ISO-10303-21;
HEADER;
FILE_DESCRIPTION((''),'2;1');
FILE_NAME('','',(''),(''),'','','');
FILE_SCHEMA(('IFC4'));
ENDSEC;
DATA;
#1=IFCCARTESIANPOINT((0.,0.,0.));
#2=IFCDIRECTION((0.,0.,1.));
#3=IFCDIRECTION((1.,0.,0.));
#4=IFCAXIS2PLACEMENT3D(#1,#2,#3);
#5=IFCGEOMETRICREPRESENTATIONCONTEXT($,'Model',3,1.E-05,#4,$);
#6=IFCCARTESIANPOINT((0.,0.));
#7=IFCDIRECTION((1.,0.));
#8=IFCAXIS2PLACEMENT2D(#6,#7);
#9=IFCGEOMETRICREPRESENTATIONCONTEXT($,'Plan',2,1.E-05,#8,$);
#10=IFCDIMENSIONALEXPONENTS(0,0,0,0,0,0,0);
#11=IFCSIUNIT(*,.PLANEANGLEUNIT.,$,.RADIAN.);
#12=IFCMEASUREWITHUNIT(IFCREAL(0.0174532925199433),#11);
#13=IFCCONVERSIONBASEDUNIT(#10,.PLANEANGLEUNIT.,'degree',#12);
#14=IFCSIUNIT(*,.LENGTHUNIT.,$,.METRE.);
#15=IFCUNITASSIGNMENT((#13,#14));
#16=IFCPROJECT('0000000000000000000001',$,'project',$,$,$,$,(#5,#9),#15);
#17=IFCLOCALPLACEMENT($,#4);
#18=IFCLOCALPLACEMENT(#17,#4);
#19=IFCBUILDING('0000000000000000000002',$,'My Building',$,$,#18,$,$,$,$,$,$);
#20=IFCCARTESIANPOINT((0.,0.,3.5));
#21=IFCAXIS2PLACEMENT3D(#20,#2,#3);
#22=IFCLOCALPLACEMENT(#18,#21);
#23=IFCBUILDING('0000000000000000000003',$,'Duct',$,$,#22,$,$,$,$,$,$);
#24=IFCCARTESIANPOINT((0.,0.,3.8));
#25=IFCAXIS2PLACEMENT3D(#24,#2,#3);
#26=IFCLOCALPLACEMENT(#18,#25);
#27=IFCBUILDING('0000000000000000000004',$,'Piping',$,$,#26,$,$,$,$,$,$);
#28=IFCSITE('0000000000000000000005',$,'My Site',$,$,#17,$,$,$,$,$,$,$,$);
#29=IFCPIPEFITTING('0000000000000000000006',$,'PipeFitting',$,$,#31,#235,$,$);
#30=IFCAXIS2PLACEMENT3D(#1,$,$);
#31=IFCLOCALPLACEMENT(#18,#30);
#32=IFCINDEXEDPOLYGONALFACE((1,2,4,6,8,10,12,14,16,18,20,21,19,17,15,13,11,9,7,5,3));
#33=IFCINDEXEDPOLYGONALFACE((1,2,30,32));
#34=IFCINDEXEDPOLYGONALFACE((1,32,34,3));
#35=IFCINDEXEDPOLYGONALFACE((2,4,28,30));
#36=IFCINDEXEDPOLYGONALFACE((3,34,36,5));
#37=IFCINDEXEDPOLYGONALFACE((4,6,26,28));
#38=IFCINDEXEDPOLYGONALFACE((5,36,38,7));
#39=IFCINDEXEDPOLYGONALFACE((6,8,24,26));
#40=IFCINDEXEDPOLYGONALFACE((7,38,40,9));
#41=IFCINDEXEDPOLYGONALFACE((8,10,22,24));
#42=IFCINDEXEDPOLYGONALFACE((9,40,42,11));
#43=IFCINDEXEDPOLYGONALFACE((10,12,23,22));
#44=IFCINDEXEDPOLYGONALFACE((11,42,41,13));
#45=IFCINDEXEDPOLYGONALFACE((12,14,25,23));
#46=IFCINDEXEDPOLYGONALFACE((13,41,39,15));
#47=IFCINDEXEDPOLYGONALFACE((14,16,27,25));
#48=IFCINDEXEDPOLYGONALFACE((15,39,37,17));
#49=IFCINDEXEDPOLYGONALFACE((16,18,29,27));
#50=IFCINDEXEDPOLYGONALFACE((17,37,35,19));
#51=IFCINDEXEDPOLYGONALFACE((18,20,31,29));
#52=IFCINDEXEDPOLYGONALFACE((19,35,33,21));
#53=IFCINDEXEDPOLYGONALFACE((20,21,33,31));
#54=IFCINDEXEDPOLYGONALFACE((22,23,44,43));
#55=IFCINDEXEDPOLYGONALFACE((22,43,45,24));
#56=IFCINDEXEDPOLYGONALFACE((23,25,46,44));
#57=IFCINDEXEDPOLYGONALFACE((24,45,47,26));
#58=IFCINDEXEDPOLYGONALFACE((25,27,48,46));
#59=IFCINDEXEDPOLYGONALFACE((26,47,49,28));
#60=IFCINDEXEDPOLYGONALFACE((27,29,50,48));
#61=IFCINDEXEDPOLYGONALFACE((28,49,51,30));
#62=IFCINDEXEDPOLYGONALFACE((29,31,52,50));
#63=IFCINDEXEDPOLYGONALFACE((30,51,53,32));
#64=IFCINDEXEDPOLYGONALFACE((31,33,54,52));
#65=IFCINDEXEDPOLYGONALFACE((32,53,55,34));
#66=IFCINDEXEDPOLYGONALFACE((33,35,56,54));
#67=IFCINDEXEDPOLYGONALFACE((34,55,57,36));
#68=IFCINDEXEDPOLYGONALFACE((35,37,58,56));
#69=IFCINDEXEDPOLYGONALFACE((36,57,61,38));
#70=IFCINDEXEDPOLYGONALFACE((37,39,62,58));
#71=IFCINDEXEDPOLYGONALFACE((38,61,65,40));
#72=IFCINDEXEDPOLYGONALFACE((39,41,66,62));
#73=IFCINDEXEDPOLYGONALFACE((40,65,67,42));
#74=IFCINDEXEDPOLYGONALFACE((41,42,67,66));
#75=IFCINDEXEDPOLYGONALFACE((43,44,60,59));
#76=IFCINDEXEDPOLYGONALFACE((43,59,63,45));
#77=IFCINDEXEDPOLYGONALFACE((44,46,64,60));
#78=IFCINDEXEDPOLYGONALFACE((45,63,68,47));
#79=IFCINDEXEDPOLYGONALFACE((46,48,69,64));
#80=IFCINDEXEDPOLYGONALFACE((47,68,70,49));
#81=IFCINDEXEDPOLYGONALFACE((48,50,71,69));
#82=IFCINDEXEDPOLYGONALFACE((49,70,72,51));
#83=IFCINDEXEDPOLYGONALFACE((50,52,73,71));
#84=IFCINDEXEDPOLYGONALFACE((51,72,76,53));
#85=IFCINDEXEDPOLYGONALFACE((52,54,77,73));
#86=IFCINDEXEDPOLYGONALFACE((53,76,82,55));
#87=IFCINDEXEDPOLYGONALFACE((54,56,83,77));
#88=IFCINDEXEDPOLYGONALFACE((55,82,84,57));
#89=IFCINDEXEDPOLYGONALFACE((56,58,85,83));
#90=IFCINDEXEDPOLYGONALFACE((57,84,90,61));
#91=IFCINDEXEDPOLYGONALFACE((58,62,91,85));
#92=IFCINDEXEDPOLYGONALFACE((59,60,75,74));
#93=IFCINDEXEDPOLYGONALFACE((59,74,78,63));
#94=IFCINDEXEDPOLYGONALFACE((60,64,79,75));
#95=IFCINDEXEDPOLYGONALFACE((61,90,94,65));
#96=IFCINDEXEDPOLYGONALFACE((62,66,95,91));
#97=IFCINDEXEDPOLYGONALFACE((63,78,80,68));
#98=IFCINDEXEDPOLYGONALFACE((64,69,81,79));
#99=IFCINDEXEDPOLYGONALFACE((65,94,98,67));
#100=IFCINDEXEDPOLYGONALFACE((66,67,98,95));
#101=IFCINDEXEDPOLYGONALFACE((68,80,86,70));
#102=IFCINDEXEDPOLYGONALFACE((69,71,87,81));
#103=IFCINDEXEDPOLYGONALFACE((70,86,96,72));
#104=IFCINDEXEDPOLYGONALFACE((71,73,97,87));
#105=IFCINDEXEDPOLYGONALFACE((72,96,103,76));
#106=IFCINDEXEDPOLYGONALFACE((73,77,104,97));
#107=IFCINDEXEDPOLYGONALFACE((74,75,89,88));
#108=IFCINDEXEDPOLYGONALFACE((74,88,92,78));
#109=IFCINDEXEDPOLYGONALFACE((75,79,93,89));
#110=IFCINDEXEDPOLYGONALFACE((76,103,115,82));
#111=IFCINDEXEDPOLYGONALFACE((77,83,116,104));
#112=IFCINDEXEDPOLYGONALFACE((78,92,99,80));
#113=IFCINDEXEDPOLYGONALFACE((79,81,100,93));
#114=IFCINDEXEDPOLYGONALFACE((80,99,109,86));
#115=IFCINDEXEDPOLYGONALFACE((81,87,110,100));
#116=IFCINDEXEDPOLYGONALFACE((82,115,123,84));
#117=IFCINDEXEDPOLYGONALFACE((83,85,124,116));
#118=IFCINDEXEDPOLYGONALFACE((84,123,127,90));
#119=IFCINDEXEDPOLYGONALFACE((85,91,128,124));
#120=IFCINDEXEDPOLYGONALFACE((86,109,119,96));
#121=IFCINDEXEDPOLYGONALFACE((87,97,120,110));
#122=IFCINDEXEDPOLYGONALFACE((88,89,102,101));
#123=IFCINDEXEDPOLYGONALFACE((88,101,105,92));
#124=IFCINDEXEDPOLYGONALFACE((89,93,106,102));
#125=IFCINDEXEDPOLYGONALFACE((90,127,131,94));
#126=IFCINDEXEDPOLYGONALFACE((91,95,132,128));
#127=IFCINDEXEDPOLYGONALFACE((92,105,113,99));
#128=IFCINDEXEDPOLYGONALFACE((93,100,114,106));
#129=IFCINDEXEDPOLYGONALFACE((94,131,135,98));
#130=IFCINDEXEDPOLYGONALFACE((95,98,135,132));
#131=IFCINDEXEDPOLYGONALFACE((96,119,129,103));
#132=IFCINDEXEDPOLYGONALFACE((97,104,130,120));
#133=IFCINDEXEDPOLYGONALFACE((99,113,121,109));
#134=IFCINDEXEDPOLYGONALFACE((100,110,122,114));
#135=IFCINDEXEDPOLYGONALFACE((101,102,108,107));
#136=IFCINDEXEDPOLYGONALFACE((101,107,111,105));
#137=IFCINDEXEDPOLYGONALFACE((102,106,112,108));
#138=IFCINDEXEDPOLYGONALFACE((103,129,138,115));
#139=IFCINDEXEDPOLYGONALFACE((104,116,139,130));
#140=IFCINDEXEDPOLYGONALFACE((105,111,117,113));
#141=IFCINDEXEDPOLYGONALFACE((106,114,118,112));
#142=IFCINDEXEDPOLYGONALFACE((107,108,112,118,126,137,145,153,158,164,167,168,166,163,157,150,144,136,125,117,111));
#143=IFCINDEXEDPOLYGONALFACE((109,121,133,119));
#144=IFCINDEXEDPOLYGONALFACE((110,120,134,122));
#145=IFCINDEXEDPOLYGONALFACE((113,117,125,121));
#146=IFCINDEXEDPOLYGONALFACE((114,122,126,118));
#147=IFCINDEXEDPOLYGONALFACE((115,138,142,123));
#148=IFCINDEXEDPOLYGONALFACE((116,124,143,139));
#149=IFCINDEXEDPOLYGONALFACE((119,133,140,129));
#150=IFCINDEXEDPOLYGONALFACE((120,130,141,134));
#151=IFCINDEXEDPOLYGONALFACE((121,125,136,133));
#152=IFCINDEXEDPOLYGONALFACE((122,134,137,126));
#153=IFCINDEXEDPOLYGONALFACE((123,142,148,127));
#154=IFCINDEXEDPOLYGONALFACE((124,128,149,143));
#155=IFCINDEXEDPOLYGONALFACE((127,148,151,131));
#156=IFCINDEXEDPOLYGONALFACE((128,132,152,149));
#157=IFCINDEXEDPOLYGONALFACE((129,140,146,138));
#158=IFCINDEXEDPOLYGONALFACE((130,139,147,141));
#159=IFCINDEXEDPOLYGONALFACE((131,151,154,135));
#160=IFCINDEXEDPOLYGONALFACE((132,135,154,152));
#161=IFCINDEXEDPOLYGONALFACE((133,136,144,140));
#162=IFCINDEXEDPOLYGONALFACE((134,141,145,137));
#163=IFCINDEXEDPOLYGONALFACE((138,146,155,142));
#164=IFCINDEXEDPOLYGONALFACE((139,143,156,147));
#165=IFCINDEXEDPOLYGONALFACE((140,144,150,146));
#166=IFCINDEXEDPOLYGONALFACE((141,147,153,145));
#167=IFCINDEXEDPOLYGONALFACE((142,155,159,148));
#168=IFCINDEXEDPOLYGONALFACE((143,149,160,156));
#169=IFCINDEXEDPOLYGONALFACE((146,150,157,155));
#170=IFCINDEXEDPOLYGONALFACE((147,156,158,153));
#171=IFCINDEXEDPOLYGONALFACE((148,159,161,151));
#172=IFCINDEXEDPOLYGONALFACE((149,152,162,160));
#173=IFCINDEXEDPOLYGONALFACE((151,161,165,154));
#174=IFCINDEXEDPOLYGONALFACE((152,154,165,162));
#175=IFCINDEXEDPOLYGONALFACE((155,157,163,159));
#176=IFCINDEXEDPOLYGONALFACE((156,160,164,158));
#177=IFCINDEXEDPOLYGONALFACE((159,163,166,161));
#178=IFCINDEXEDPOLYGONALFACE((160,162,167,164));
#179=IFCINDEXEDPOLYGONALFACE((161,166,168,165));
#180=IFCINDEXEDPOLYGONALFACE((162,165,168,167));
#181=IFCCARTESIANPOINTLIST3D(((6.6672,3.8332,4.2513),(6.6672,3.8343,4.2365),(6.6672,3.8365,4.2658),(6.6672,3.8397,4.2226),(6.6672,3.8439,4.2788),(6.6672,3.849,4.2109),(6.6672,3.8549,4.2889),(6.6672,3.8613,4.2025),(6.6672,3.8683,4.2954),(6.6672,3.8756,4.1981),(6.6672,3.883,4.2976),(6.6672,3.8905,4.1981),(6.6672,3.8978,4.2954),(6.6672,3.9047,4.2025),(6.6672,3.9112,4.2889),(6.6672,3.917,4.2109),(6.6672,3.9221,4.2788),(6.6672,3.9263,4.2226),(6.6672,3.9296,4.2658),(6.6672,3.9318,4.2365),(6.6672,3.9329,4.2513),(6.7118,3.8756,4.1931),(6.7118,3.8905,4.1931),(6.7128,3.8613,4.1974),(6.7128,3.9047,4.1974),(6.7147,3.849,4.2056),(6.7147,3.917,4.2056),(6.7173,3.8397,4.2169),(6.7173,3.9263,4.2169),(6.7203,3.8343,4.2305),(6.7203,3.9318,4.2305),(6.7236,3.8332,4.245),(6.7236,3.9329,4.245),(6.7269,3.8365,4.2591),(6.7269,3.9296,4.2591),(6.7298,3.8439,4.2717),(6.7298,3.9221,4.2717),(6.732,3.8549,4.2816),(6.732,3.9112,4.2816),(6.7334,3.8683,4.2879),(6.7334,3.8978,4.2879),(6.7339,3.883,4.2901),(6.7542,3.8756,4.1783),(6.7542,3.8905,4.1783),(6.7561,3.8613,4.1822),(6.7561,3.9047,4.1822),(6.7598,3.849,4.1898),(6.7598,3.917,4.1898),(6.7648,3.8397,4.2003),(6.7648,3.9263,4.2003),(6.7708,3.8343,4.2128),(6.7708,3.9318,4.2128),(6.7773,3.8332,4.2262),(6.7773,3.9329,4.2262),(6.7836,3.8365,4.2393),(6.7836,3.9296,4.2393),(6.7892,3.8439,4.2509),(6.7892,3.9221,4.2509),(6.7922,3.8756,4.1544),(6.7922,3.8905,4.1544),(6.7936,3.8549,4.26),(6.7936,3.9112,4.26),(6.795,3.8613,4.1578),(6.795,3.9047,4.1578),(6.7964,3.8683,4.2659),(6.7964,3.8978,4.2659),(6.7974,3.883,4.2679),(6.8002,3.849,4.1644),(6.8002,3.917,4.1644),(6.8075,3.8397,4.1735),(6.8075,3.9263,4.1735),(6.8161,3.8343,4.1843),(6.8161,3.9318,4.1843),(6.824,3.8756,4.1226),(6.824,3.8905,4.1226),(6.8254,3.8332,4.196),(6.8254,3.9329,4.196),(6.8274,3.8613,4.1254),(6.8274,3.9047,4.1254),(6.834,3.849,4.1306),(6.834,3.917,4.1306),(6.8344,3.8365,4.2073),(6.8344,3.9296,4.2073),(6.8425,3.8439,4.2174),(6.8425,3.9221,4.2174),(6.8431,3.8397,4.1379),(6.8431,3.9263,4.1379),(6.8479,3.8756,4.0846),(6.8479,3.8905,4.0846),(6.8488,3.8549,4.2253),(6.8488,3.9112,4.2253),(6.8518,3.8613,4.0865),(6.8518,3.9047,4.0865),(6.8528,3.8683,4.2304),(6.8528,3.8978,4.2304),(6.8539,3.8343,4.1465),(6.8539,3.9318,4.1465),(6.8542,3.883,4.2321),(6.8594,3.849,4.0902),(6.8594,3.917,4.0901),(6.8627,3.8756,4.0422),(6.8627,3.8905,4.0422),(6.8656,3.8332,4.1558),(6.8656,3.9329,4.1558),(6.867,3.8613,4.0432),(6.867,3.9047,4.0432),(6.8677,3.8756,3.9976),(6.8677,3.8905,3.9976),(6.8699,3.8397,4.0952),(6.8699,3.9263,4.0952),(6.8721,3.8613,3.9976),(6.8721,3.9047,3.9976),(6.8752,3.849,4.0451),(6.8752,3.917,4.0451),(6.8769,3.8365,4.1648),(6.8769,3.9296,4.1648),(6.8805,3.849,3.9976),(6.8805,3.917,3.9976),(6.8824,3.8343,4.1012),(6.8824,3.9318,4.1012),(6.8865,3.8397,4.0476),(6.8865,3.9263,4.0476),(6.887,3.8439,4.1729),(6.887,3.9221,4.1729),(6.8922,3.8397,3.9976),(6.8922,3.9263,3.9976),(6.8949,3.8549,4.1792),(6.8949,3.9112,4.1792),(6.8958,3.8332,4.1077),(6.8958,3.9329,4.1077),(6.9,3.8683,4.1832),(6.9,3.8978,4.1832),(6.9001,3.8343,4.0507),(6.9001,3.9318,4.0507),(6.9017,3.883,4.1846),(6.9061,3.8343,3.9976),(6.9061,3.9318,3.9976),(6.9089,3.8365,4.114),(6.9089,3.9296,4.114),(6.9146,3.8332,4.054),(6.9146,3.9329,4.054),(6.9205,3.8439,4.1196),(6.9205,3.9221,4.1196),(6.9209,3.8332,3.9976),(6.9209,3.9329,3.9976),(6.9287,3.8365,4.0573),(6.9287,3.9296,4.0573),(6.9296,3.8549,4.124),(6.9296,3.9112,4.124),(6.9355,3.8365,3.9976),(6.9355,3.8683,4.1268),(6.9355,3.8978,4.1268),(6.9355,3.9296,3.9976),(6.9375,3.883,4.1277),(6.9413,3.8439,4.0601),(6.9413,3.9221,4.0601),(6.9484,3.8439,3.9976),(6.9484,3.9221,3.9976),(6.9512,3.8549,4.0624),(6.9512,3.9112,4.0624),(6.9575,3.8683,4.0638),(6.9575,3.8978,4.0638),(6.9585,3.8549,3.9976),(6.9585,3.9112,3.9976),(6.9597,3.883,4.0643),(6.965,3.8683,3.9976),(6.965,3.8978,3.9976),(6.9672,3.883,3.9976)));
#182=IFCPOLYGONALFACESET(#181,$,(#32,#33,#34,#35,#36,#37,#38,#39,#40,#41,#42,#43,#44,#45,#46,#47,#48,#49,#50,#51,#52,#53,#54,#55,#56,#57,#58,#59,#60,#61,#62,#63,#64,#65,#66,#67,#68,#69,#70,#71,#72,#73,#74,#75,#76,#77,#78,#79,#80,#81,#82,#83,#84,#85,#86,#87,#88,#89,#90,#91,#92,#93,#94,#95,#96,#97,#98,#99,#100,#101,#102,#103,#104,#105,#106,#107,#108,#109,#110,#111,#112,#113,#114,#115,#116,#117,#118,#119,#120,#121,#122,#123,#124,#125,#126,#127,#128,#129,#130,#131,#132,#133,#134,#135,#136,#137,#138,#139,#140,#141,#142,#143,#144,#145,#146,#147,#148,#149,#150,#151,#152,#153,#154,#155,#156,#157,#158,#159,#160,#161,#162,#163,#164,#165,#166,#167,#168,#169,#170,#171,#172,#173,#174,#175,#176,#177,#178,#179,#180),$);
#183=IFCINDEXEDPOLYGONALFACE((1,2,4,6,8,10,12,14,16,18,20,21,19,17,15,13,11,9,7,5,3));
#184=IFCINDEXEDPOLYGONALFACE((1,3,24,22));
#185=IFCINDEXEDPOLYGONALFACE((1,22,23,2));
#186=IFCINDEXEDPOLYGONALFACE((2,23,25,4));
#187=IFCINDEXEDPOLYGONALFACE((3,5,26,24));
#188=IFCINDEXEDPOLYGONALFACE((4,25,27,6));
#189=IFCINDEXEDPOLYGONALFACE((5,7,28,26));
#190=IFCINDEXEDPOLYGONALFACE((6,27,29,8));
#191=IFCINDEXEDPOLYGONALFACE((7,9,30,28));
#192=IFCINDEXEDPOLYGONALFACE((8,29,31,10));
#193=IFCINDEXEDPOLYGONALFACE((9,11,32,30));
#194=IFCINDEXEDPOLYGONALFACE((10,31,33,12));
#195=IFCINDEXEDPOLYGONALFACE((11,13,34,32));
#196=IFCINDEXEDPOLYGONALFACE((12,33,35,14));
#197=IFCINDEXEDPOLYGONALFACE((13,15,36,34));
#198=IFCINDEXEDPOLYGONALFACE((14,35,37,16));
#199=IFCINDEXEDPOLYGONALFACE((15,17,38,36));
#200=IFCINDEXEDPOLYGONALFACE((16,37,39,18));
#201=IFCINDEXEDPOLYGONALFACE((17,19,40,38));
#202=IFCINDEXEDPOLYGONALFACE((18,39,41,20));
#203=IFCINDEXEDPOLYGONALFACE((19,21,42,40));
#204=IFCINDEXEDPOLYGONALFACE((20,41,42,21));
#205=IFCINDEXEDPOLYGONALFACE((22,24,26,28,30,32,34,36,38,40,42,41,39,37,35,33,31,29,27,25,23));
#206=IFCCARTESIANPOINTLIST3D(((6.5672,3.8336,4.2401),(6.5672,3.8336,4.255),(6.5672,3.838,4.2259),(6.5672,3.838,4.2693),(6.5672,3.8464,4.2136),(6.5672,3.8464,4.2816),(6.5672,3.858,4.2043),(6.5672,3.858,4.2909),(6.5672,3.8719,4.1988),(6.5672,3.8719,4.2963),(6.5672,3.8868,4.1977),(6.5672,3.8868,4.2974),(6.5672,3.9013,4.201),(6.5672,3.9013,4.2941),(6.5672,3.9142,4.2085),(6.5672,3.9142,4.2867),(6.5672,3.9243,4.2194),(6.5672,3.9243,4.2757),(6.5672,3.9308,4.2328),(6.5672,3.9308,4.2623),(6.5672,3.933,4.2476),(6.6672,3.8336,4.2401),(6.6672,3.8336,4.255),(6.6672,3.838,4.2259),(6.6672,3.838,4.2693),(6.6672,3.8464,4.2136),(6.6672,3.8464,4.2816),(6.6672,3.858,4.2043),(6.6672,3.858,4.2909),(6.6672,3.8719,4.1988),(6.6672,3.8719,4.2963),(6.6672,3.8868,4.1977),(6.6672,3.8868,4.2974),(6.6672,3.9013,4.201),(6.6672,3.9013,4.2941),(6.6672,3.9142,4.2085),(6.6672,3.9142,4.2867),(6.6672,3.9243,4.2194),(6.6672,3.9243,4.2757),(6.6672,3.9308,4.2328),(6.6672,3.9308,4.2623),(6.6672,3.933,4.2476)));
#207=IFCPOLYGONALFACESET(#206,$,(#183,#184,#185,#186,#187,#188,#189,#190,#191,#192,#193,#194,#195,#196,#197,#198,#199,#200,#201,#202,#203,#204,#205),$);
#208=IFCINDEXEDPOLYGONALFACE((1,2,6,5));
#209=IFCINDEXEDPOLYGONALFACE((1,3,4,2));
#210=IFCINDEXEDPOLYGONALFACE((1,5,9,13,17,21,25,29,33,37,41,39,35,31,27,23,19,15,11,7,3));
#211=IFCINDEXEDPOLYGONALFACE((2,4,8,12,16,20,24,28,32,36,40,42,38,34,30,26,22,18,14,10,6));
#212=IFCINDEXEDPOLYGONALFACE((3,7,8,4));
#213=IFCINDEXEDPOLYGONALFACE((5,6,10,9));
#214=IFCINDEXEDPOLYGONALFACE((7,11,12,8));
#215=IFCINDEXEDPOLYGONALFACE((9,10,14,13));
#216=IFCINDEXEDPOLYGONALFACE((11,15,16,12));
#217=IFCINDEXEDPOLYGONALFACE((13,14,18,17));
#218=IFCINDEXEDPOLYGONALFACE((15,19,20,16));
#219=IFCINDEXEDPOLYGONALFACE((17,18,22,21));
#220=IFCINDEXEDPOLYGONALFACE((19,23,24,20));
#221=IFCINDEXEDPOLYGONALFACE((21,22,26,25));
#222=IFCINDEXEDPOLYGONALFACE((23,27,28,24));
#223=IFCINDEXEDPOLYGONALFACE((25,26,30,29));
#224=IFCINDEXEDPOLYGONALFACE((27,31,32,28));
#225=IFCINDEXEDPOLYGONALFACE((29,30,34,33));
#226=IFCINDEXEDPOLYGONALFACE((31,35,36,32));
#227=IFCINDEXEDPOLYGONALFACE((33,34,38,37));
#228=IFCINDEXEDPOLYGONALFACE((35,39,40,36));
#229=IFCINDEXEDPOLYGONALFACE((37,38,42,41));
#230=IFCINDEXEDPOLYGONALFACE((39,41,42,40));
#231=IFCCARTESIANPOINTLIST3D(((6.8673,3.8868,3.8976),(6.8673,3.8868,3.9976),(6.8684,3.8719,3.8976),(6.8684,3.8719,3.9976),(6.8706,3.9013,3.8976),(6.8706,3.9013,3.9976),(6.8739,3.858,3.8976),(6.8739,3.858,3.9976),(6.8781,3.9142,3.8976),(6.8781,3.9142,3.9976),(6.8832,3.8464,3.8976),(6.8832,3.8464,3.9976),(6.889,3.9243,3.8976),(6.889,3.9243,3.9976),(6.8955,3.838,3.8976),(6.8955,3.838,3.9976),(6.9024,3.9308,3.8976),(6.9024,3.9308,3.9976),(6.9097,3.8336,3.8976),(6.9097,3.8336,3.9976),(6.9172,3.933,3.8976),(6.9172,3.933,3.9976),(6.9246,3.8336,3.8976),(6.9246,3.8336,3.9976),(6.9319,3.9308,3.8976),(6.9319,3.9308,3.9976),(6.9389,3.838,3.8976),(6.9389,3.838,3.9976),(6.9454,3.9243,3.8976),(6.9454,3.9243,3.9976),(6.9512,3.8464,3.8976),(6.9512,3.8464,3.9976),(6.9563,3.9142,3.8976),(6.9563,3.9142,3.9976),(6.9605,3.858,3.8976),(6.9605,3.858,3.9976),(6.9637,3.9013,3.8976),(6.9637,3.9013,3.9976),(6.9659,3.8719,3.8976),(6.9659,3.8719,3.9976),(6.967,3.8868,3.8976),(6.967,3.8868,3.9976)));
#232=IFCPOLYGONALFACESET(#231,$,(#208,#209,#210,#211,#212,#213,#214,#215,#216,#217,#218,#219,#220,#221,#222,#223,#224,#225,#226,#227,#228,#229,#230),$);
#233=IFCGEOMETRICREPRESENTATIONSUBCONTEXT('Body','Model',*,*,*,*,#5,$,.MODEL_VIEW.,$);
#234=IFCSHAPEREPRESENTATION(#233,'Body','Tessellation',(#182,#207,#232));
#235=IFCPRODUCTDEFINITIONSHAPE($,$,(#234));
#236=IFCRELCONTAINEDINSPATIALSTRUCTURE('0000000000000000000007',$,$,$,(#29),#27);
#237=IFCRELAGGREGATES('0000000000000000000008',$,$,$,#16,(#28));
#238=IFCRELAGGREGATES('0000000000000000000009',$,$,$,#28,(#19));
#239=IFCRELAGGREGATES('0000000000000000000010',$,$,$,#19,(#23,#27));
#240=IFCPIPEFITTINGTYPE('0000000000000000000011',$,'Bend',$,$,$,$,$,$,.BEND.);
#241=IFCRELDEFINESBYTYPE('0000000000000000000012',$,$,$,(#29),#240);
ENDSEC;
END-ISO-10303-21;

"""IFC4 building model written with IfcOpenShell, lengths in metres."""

from ifc_helpers import new_model, entity, si_unit, converted_unit, frame, origin_with_axes, origin_2d_with_axis, place, context, subcontext, project, spatial, circle, extrude, source, transform, mapped, type_object, type_shapes, element, save


model = new_model("IFC4")

# Units and contexts
model_context = context("Model", 3, precision=1e-05, world=origin_with_axes())
plan_context = context("Plan", 2, precision=1e-05, world=origin_2d_with_axis())
body_context = subcontext(model_context, "Body", "Model", "MODEL_VIEW")
ifc_project = project(units=[converted_unit("PLANEANGLEUNIT", "degree", entity("IfcReal", 0.0174532925199433), si_unit("PLANEANGLEUNIT", "RADIAN"), dimensions=[0, 0, 0, 0, 0, 0, 0]), si_unit("LENGTHUNIT", "METRE")], contexts=[model_context, plan_context])

# Site, building
site_placement = place(None, origin_with_axes())
site = spatial("IfcSite", under=ifc_project, at=site_placement, Name="My Site")
building_1_placement = place(site_placement, origin_with_axes())
building_1 = spatial("IfcBuilding", under=site, at=building_1_placement, Name="My Building")

# Shared definitions
building_2_placement = place(building_1_placement, frame((0.0, 0.0, 3.5), z_axis=(0.0, 0.0, 1.0), x_axis=(1.0, 0.0, 0.0)))
building_2 = spatial("IfcBuilding", under=building_1, at=building_2_placement, Name="Duct")

# Shared definitions
building_3_placement = place(building_1_placement, frame((0.0, 0.0, 3.8), z_axis=(0.0, 0.0, 1.0), x_axis=(1.0, 0.0, 0.0)))
building_3 = spatial("IfcBuilding", under=building_1, at=building_3_placement, Name="Piping")

# Pipe fitting
pipe_fitting_type_1 = type_object("IfcPipeFittingType", Name="Bend", PredefinedType="BEND")
shared_shape = source(origin_with_axes(), body_context, "Body", "SolidModel", [
    entity("IfcSweptDiskSolid", entity("IfcIndexedPolyCurve", entity("IfcCartesianPointList3D", [[0.0, 0.0, 0.1], [0.0, -0.0732, 0.2768], [0.0, -0.25, 0.35]]), [entity("IfcArcIndex", [1, 2, 3])]), 0.05),
    extrude(circle(Radius=0.05), origin_with_axes(), (0.0, 0.0, 1.0), 0.1),
    extrude(circle(Radius=0.05), frame((0.0, -0.25, 0.35), z_axis=(0.0, -1.0, -0.000001), x_axis=(1.0, 0.0, 0.0)), (0.0, 0.0, 1.0), 0.1),
])
type_shapes(pipe_fitting_type_1, [shared_shape])
for number, where, z_axis, x_axis, name in (
    (1, (6.5672, 3.883, 0.4476), (1.0, -0.000001, 0.000001), (0.000001, 1.0, 0.0), "PipeFitting"),
):
    element("IfcPipeFitting", number, at=place(building_3_placement, frame(where, z_axis=z_axis, x_axis=x_axis)), inside=building_3, type_object=pipe_fitting_type_1, Name=name, context=body_context, shape_type="MappedRepresentation", body=[
        mapped(shared_shape, transform((0.0, 0.0, 0.0), x_axis=(1.0, 0.0, 0.0), y_axis=(0.0, 1.0, 0.0), z_axis=(0.0, 0.0, 1.0), scale=1.0)),
    ])

save(model, "model.ifc")
